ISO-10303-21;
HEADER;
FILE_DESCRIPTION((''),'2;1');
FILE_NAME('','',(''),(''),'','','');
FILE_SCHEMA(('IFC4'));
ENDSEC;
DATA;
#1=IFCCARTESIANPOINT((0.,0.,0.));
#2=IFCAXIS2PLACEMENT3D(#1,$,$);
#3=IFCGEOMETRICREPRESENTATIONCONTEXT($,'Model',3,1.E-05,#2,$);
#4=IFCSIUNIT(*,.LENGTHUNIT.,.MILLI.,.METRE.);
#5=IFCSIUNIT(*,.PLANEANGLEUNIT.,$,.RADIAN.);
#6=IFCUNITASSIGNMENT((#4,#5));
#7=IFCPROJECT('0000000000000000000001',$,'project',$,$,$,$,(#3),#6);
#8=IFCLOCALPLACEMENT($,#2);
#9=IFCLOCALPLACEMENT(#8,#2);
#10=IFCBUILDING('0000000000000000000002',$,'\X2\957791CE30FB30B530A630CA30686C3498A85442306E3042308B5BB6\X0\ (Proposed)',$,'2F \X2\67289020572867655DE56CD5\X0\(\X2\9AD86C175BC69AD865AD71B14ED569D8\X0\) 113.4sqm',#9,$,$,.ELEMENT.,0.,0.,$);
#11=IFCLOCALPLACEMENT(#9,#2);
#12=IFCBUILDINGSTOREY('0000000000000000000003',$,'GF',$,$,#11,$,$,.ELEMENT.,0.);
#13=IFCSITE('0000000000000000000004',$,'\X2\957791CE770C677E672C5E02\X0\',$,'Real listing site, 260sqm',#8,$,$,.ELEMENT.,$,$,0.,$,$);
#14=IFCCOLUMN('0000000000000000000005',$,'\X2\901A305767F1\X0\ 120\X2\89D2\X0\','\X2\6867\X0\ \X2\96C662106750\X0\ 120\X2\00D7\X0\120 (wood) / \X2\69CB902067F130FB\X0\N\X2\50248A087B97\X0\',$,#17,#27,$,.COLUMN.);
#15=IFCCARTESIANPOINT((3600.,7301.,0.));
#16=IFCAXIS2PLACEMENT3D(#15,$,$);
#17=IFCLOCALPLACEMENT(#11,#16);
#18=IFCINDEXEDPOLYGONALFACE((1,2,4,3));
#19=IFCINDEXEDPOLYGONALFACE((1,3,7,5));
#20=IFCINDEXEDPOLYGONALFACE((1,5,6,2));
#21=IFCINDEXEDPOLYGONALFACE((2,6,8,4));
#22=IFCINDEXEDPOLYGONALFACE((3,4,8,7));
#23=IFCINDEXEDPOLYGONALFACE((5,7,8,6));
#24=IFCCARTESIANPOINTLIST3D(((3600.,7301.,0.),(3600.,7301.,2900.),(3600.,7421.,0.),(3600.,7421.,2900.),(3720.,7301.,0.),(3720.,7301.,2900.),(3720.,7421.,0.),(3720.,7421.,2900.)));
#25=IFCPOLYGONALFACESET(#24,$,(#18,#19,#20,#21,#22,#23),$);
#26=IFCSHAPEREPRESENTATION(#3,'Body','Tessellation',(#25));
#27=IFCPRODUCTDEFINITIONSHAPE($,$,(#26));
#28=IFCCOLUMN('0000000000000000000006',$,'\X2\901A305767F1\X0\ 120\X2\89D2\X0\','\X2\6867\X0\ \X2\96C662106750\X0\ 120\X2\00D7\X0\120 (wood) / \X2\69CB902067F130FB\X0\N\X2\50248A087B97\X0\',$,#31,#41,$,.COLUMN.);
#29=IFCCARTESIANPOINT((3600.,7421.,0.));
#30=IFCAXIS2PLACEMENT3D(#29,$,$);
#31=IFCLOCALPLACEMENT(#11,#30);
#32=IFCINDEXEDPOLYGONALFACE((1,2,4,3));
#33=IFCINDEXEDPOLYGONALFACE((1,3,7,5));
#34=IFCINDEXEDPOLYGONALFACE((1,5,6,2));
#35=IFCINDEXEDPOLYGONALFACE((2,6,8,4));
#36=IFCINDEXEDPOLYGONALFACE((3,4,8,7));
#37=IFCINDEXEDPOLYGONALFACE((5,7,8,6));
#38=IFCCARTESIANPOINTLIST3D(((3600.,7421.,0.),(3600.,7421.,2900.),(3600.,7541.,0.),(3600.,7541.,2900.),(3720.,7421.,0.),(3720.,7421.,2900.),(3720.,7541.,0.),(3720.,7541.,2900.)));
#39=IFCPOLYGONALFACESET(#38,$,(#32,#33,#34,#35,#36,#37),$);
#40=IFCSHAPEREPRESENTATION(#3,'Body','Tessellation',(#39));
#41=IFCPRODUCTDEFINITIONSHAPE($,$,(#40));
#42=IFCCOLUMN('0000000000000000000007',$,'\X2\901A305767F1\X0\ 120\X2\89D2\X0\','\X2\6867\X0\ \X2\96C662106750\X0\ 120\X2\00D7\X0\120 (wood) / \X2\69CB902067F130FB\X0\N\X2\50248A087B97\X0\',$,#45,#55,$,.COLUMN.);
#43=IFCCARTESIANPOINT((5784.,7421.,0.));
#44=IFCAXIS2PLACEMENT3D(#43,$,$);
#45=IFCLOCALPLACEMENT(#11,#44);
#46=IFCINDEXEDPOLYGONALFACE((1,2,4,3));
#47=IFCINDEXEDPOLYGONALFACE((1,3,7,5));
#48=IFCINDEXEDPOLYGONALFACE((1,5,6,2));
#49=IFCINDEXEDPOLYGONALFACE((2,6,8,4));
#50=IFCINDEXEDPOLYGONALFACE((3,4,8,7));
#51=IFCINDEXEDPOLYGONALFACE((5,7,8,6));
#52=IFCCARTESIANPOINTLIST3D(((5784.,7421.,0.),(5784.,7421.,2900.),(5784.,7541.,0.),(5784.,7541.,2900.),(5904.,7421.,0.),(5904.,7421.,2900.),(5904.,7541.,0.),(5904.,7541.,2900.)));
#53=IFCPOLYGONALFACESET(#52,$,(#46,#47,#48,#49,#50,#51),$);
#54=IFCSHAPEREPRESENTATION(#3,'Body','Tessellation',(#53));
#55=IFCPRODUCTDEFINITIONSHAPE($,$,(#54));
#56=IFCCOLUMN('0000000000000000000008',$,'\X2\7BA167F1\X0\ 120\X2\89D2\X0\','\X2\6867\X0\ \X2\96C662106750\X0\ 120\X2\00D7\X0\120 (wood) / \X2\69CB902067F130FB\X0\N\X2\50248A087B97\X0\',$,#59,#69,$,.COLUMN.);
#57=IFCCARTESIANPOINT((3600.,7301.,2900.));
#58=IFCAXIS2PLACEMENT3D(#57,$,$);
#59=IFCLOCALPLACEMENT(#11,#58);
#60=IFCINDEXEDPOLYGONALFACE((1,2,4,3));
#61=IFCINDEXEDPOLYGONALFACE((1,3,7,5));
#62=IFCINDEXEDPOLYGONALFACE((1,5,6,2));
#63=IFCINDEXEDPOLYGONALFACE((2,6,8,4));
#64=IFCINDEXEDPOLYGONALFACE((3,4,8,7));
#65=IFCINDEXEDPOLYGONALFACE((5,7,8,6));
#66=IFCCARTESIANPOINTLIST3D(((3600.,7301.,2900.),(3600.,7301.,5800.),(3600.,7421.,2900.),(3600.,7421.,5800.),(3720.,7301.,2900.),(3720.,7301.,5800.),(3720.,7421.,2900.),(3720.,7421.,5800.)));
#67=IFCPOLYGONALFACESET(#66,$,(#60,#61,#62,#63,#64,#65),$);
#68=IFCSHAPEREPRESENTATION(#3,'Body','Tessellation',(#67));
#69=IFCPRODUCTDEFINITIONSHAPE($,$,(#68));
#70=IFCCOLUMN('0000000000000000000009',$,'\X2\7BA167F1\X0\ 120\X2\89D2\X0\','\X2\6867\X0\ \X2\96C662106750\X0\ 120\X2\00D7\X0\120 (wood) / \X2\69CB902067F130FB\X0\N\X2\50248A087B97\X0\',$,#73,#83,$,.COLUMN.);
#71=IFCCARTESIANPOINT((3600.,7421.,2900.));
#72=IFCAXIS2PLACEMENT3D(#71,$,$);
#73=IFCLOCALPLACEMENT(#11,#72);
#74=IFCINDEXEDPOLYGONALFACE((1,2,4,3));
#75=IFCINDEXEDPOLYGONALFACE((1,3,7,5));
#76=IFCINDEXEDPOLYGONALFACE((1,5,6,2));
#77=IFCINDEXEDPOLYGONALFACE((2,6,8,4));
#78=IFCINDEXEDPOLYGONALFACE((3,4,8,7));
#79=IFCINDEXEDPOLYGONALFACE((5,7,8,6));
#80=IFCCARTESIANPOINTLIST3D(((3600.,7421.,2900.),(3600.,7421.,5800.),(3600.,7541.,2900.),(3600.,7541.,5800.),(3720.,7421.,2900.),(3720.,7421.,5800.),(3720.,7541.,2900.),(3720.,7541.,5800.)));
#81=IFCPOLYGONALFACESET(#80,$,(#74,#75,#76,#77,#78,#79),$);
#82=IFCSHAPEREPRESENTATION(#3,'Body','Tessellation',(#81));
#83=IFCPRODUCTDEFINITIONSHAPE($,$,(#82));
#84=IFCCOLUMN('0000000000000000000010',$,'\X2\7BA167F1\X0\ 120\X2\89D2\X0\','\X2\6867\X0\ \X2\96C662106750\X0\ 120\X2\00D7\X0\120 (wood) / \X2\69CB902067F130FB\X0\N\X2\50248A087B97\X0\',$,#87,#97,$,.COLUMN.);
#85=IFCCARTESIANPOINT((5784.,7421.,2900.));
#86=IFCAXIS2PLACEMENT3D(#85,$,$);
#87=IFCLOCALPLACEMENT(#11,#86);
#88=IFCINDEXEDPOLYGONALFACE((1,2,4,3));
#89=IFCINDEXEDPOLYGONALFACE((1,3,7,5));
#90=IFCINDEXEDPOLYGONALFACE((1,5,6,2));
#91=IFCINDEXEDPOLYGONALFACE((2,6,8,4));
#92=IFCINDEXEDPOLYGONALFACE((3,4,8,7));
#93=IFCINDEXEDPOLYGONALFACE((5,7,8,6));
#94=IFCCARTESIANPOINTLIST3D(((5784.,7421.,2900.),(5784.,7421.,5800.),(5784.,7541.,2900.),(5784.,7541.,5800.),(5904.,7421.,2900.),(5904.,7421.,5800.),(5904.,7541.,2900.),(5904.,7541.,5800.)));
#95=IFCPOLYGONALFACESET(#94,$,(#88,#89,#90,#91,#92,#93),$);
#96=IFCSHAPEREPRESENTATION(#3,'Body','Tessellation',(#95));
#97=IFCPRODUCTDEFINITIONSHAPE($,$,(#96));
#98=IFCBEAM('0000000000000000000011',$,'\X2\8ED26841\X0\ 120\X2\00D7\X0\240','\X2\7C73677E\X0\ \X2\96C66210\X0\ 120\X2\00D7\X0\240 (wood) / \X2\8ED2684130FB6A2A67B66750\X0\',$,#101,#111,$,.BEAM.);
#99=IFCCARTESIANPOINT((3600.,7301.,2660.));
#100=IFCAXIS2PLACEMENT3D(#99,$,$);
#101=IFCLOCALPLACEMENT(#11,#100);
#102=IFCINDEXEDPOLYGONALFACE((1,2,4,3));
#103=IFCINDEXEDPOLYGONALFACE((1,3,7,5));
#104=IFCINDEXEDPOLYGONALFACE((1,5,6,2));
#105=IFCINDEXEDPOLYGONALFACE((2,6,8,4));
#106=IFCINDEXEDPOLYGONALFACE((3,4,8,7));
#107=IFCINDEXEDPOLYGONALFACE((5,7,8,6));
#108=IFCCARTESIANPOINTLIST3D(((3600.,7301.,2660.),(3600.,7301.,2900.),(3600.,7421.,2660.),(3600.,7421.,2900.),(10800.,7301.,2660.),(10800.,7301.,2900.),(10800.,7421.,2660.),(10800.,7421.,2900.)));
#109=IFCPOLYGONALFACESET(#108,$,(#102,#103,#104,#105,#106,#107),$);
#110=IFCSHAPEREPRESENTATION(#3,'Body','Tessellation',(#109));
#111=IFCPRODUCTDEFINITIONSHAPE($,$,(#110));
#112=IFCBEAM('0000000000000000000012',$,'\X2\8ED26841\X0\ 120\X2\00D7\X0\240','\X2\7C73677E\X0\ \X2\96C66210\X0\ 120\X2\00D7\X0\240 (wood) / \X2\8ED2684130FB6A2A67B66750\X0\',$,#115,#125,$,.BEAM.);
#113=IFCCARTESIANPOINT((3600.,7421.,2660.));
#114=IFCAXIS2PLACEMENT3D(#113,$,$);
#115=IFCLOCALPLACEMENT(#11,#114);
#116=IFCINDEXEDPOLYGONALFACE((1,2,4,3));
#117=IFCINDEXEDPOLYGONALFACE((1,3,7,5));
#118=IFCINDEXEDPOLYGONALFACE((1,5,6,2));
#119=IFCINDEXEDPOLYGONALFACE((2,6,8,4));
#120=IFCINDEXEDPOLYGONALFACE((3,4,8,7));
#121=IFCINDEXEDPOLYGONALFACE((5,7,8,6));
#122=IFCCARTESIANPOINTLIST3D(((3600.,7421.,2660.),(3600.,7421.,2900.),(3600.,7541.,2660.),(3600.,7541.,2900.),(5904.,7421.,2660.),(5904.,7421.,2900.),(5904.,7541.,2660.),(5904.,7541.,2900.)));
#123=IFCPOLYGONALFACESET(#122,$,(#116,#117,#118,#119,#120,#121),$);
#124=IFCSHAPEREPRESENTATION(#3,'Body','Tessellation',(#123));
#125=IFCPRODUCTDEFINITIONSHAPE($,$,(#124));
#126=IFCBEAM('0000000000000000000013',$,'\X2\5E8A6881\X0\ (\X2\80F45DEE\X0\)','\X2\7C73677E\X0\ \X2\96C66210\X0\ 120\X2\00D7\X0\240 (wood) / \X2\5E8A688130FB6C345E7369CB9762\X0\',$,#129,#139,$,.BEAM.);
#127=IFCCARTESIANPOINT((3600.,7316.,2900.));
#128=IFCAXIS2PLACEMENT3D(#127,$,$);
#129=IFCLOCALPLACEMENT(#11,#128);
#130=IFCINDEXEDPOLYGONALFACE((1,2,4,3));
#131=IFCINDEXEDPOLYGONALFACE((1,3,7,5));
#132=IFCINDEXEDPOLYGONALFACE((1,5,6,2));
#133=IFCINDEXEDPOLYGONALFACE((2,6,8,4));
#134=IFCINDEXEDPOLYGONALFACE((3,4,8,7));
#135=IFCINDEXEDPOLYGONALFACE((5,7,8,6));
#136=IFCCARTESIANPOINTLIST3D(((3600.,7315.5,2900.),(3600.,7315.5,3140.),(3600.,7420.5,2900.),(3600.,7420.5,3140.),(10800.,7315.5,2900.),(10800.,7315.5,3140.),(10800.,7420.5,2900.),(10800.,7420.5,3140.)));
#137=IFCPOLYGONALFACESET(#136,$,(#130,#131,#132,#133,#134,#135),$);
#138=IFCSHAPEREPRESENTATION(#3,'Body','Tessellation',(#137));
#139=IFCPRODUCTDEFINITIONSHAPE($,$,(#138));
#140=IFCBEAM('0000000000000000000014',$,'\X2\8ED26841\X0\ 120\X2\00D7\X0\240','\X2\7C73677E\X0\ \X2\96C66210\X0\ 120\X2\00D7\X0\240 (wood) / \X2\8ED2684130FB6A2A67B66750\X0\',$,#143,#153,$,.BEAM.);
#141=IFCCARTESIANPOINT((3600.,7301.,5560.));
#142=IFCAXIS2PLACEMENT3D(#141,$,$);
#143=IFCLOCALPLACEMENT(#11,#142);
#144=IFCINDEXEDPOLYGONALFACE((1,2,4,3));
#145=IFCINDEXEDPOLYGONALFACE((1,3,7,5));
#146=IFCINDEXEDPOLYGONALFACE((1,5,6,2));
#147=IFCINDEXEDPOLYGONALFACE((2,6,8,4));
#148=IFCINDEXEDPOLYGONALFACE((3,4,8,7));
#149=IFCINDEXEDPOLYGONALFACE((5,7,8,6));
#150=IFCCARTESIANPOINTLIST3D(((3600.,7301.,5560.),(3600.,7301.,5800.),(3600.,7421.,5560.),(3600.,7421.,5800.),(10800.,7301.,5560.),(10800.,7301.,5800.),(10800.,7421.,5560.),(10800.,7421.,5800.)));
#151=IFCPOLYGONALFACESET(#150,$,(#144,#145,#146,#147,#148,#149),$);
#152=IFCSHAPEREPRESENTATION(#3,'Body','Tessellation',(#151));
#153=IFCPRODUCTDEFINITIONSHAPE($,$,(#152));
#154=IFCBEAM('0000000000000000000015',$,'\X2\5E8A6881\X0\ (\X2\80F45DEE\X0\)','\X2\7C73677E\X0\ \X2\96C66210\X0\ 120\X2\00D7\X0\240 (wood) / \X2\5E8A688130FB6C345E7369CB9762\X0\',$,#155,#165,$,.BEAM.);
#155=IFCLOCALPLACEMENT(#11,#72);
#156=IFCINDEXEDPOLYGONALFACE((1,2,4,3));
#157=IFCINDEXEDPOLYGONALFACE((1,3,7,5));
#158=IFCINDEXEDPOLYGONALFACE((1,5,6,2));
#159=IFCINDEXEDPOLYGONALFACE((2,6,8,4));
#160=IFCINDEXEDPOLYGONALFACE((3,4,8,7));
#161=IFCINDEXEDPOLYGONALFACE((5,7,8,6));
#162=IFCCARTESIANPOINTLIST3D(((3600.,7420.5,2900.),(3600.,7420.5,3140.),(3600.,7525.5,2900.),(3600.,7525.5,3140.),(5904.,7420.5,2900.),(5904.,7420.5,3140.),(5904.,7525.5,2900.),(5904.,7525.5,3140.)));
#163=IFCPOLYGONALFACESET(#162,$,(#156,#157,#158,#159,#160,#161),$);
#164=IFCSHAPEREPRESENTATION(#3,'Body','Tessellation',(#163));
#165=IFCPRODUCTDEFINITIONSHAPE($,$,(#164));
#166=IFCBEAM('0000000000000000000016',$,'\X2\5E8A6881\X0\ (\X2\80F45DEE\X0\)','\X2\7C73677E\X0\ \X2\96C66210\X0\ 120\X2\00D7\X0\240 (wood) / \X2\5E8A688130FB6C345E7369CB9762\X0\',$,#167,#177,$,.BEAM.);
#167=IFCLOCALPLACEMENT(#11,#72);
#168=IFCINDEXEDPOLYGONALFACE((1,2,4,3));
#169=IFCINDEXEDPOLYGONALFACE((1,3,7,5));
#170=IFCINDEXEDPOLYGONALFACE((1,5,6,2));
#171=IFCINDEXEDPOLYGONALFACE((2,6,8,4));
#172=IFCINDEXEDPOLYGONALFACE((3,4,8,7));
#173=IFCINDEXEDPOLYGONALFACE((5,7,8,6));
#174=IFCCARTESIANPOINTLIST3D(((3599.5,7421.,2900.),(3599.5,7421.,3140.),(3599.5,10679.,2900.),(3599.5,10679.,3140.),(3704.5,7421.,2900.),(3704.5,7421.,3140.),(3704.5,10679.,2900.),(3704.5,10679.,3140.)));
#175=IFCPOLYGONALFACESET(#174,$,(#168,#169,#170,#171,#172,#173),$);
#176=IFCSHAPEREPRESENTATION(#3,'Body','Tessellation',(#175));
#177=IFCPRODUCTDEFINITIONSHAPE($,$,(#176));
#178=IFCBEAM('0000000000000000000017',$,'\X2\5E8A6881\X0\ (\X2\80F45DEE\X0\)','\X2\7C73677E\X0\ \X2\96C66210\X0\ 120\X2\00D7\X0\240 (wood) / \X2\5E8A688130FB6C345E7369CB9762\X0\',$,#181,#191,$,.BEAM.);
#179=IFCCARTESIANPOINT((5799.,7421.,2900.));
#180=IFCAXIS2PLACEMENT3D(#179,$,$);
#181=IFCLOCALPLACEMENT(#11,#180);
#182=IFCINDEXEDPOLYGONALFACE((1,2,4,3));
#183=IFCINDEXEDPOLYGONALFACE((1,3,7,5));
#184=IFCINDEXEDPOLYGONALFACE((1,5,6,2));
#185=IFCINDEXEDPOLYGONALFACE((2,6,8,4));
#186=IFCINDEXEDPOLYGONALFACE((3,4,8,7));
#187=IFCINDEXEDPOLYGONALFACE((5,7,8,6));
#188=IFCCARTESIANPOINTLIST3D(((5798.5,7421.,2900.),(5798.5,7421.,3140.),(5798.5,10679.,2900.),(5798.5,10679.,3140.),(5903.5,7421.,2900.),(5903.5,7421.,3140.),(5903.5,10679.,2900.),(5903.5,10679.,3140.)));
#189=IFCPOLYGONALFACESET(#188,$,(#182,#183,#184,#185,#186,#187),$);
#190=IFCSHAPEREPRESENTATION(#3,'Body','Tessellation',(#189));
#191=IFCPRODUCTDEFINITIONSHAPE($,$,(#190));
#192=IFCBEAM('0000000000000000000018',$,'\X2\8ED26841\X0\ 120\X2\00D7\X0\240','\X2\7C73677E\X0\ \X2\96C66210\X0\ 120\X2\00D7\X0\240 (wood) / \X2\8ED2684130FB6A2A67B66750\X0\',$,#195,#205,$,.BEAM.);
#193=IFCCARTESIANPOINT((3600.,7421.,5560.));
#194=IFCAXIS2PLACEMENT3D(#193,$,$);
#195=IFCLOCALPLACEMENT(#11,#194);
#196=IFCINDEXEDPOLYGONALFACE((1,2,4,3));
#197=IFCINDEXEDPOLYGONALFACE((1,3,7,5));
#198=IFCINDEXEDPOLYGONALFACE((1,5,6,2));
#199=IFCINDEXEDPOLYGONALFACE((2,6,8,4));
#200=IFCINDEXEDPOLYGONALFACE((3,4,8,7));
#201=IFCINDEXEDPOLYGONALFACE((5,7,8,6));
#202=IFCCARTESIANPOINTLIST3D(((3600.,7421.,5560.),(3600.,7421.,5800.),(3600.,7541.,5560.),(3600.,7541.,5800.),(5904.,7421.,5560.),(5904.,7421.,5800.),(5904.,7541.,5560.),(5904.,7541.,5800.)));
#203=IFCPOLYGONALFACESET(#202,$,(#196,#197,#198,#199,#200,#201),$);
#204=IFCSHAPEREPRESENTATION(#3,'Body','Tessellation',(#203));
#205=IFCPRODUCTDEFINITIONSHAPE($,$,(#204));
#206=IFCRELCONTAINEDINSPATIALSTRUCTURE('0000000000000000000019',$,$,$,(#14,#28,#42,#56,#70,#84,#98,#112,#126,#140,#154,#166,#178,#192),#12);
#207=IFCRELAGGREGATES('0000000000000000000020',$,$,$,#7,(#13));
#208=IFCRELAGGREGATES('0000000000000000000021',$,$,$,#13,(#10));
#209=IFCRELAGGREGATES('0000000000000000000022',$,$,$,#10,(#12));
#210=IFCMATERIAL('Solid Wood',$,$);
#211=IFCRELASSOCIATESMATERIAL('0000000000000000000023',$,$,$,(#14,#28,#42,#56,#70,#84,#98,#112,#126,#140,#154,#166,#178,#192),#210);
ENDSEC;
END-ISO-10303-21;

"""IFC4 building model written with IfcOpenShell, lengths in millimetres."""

from ifc_helpers import new_model, si_unit, frame, frame_2d, origin, place, context, project, spatial, rectangle, extrude, material, element, save


model = new_model("IFC4")

# Units and contexts
model_context = context("Model", 3, precision=1e-05, world=origin())
ifc_project = project(units=[si_unit("LENGTHUNIT", "METRE", prefix="MILLI"), si_unit("PLANEANGLEUNIT", "RADIAN")], contexts=[model_context])

# Site, building, storey
site_placement = place(None, origin())
site = spatial("IfcSite", under=ifc_project, at=site_placement, Name="長野県松本市", ObjectType="Real listing site, 260sqm", CompositionType="ELEMENT", RefElevation=0.0)
building_placement = place(site_placement, origin())
building = spatial("IfcBuilding", under=site, at=building_placement, Name="長野・サウナと水風呂のある家 (Proposed)", ObjectType="2F 木造在来工法(高気密高断熱仕様) 113.4sqm", CompositionType="ELEMENT", ElevationOfRefHeight=0.0, ElevationOfTerrain=0.0)
storey_placement = place(building_placement, origin())
storey = spatial("IfcBuildingStorey", under=building, at=storey_placement, Name="GF", CompositionType="ELEMENT", Elevation=0.0)

# Columns
ifc_material_1 = material(Name="Solid Wood")
column_1_placement = place(storey_placement, frame((3600.0, 7301.0, 0.0)))
element("IfcColumn", 1, at=column_1_placement, inside=storey, material=ifc_material_1, Name="通し柱 120角", Description="桧 集成材 120×120 (wood) / 構造柱・N値計算", PredefinedType="COLUMN", context=model_context, shape_type="SweptSolid", body=[
    extrude(rectangle(XDim=120.0, YDim=120.0, at=frame_2d((60.0, 60.0))), frame((3600.0, 7301.0, 0.0)), (0.0, 0.0, 1.0), 2900.0),
])
column_2_placement = place(storey_placement, frame((3600.0, 7421.0, 0.0)))
element("IfcColumn", 2, at=column_2_placement, inside=storey, material=ifc_material_1, Name="通し柱 120角", Description="桧 集成材 120×120 (wood) / 構造柱・N値計算", PredefinedType="COLUMN", context=model_context, shape_type="SweptSolid", body=[
    extrude(rectangle(XDim=120.0, YDim=120.0, at=frame_2d((60.0, 60.0))), frame((3600.0, 7421.0, 0.0)), (0.0, 0.0, 1.0), 2900.0),
])
column_3_placement = place(storey_placement, frame((5784.0, 7421.0, 0.0)))
element("IfcColumn", 3, at=column_3_placement, inside=storey, material=ifc_material_1, Name="通し柱 120角", Description="桧 集成材 120×120 (wood) / 構造柱・N値計算", PredefinedType="COLUMN", context=model_context, shape_type="SweptSolid", body=[
    extrude(rectangle(XDim=120.0, YDim=120.0, at=frame_2d((60.0, 60.0))), frame((5784.0, 7421.0, 0.0)), (0.0, 0.0, 1.0), 2900.0),
])
column_4_placement = place(storey_placement, frame((3600.0, 7301.0, 2900.0)))
element("IfcColumn", 4, at=column_4_placement, inside=storey, material=ifc_material_1, Name="管柱 120角", Description="桧 集成材 120×120 (wood) / 構造柱・N値計算", PredefinedType="COLUMN", context=model_context, shape_type="SweptSolid", body=[
    extrude(rectangle(XDim=120.0, YDim=120.0, at=frame_2d((60.0, 60.0))), frame((3600.0, 7301.0, 2900.0)), (0.0, 0.0, 1.0), 2900.0),
])
column_5_placement = place(storey_placement, frame((3600.0, 7421.0, 2900.0)))
element("IfcColumn", 5, at=column_5_placement, inside=storey, material=ifc_material_1, Name="管柱 120角", Description="桧 集成材 120×120 (wood) / 構造柱・N値計算", PredefinedType="COLUMN", context=model_context, shape_type="SweptSolid", body=[
    extrude(rectangle(XDim=120.0, YDim=120.0, at=frame_2d((60.0, 60.0))), frame((3600.0, 7421.0, 2900.0)), (0.0, 0.0, 1.0), 2900.0),
])
column_6_placement = place(storey_placement, frame((5784.0, 7421.0, 2900.0)))
element("IfcColumn", 6, at=column_6_placement, inside=storey, material=ifc_material_1, Name="管柱 120角", Description="桧 集成材 120×120 (wood) / 構造柱・N値計算", PredefinedType="COLUMN", context=model_context, shape_type="SweptSolid", body=[
    extrude(rectangle(XDim=120.0, YDim=120.0, at=frame_2d((60.0, 60.0))), frame((5784.0, 7421.0, 2900.0)), (0.0, 0.0, 1.0), 2900.0),
])

# Beams
beam_1_placement = place(storey_placement, frame((3600.0, 7301.0, 2660.0)))
element("IfcBeam", 7, at=beam_1_placement, inside=storey, material=ifc_material_1, Name="軒桁 120×240", Description="米松 集成 120×240 (wood) / 軒桁・横架材", PredefinedType="BEAM", context=model_context, shape_type="SweptSolid", body=[
    extrude(rectangle(XDim=7200.0, YDim=120.0, at=frame_2d((3600.0, 60.0))), frame((3600.0, 7301.0, 2660.0)), (0.0, 0.0, 1.0), 240.0),
])
beam_2_placement = place(storey_placement, frame((3600.0, 7421.0, 2660.0)))
element("IfcBeam", 8, at=beam_2_placement, inside=storey, material=ifc_material_1, Name="軒桁 120×240", Description="米松 集成 120×240 (wood) / 軒桁・横架材", PredefinedType="BEAM", context=model_context, shape_type="SweptSolid", body=[
    extrude(rectangle(XDim=2304.0, YDim=120.0, at=frame_2d((1152.0, 60.0))), frame((3600.0, 7421.0, 2660.0)), (0.0, 0.0, 1.0), 240.0),
])
beam_3_placement = place(storey_placement, frame((3600.0, 7316.0, 2900.0)))
element("IfcBeam", 9, at=beam_3_placement, inside=storey, material=ifc_material_1, Name="床梁 (胴差)", Description="米松 集成 120×240 (wood) / 床梁・水平構面", PredefinedType="BEAM", context=model_context, shape_type="SweptSolid", body=[
    extrude(rectangle(XDim=7200.0, YDim=105.0, at=frame_2d((3600.0, 52.0))), frame((3600.0, 7316.0, 2900.0)), (0.0, 0.0, 1.0), 240.0),
])
beam_4_placement = place(storey_placement, frame((3600.0, 7301.0, 5560.0)))
element("IfcBeam", 10, at=beam_4_placement, inside=storey, material=ifc_material_1, Name="軒桁 120×240", Description="米松 集成 120×240 (wood) / 軒桁・横架材", PredefinedType="BEAM", context=model_context, shape_type="SweptSolid", body=[
    extrude(rectangle(XDim=7200.0, YDim=120.0, at=frame_2d((3600.0, 60.0))), frame((3600.0, 7301.0, 5560.0)), (0.0, 0.0, 1.0), 240.0),
])
beam_5_placement = place(storey_placement, frame((3600.0, 7421.0, 2900.0)))
element("IfcBeam", 11, at=beam_5_placement, inside=storey, material=ifc_material_1, Name="床梁 (胴差)", Description="米松 集成 120×240 (wood) / 床梁・水平構面", PredefinedType="BEAM", context=model_context, shape_type="SweptSolid", body=[
    extrude(rectangle(XDim=2304.0, YDim=105.0, at=frame_2d((1152.0, 52.0))), frame((3600.0, 7421.0, 2900.0)), (0.0, 0.0, 1.0), 240.0),
])
beam_6_placement = place(storey_placement, frame((3600.0, 7421.0, 2900.0)))
element("IfcBeam", 12, at=beam_6_placement, inside=storey, material=ifc_material_1, Name="床梁 (胴差)", Description="米松 集成 120×240 (wood) / 床梁・水平構面", PredefinedType="BEAM", context=model_context, shape_type="SweptSolid", body=[
    extrude(rectangle(XDim=105.0, YDim=3258.0, at=frame_2d((52.0, 1629.0))), frame((3600.0, 7421.0, 2900.0)), (0.0, 0.0, 1.0), 240.0),
])
beam_7_placement = place(storey_placement, frame((5799.0, 7421.0, 2900.0)))
element("IfcBeam", 13, at=beam_7_placement, inside=storey, material=ifc_material_1, Name="床梁 (胴差)", Description="米松 集成 120×240 (wood) / 床梁・水平構面", PredefinedType="BEAM", context=model_context, shape_type="SweptSolid", body=[
    extrude(rectangle(XDim=105.0, YDim=3258.0, at=frame_2d((52.0, 1629.0))), frame((5799.0, 7421.0, 2900.0)), (0.0, 0.0, 1.0), 240.0),
])
beam_8_placement = place(storey_placement, frame((3600.0, 7421.0, 5560.0)))
element("IfcBeam", 14, at=beam_8_placement, inside=storey, material=ifc_material_1, Name="軒桁 120×240", Description="米松 集成 120×240 (wood) / 軒桁・横架材", PredefinedType="BEAM", context=model_context, shape_type="SweptSolid", body=[
    extrude(rectangle(XDim=2304.0, YDim=120.0, at=frame_2d((1152.0, 60.0))), frame((3600.0, 7421.0, 5560.0)), (0.0, 0.0, 1.0), 240.0),
])

save(model, "model.ifc")
